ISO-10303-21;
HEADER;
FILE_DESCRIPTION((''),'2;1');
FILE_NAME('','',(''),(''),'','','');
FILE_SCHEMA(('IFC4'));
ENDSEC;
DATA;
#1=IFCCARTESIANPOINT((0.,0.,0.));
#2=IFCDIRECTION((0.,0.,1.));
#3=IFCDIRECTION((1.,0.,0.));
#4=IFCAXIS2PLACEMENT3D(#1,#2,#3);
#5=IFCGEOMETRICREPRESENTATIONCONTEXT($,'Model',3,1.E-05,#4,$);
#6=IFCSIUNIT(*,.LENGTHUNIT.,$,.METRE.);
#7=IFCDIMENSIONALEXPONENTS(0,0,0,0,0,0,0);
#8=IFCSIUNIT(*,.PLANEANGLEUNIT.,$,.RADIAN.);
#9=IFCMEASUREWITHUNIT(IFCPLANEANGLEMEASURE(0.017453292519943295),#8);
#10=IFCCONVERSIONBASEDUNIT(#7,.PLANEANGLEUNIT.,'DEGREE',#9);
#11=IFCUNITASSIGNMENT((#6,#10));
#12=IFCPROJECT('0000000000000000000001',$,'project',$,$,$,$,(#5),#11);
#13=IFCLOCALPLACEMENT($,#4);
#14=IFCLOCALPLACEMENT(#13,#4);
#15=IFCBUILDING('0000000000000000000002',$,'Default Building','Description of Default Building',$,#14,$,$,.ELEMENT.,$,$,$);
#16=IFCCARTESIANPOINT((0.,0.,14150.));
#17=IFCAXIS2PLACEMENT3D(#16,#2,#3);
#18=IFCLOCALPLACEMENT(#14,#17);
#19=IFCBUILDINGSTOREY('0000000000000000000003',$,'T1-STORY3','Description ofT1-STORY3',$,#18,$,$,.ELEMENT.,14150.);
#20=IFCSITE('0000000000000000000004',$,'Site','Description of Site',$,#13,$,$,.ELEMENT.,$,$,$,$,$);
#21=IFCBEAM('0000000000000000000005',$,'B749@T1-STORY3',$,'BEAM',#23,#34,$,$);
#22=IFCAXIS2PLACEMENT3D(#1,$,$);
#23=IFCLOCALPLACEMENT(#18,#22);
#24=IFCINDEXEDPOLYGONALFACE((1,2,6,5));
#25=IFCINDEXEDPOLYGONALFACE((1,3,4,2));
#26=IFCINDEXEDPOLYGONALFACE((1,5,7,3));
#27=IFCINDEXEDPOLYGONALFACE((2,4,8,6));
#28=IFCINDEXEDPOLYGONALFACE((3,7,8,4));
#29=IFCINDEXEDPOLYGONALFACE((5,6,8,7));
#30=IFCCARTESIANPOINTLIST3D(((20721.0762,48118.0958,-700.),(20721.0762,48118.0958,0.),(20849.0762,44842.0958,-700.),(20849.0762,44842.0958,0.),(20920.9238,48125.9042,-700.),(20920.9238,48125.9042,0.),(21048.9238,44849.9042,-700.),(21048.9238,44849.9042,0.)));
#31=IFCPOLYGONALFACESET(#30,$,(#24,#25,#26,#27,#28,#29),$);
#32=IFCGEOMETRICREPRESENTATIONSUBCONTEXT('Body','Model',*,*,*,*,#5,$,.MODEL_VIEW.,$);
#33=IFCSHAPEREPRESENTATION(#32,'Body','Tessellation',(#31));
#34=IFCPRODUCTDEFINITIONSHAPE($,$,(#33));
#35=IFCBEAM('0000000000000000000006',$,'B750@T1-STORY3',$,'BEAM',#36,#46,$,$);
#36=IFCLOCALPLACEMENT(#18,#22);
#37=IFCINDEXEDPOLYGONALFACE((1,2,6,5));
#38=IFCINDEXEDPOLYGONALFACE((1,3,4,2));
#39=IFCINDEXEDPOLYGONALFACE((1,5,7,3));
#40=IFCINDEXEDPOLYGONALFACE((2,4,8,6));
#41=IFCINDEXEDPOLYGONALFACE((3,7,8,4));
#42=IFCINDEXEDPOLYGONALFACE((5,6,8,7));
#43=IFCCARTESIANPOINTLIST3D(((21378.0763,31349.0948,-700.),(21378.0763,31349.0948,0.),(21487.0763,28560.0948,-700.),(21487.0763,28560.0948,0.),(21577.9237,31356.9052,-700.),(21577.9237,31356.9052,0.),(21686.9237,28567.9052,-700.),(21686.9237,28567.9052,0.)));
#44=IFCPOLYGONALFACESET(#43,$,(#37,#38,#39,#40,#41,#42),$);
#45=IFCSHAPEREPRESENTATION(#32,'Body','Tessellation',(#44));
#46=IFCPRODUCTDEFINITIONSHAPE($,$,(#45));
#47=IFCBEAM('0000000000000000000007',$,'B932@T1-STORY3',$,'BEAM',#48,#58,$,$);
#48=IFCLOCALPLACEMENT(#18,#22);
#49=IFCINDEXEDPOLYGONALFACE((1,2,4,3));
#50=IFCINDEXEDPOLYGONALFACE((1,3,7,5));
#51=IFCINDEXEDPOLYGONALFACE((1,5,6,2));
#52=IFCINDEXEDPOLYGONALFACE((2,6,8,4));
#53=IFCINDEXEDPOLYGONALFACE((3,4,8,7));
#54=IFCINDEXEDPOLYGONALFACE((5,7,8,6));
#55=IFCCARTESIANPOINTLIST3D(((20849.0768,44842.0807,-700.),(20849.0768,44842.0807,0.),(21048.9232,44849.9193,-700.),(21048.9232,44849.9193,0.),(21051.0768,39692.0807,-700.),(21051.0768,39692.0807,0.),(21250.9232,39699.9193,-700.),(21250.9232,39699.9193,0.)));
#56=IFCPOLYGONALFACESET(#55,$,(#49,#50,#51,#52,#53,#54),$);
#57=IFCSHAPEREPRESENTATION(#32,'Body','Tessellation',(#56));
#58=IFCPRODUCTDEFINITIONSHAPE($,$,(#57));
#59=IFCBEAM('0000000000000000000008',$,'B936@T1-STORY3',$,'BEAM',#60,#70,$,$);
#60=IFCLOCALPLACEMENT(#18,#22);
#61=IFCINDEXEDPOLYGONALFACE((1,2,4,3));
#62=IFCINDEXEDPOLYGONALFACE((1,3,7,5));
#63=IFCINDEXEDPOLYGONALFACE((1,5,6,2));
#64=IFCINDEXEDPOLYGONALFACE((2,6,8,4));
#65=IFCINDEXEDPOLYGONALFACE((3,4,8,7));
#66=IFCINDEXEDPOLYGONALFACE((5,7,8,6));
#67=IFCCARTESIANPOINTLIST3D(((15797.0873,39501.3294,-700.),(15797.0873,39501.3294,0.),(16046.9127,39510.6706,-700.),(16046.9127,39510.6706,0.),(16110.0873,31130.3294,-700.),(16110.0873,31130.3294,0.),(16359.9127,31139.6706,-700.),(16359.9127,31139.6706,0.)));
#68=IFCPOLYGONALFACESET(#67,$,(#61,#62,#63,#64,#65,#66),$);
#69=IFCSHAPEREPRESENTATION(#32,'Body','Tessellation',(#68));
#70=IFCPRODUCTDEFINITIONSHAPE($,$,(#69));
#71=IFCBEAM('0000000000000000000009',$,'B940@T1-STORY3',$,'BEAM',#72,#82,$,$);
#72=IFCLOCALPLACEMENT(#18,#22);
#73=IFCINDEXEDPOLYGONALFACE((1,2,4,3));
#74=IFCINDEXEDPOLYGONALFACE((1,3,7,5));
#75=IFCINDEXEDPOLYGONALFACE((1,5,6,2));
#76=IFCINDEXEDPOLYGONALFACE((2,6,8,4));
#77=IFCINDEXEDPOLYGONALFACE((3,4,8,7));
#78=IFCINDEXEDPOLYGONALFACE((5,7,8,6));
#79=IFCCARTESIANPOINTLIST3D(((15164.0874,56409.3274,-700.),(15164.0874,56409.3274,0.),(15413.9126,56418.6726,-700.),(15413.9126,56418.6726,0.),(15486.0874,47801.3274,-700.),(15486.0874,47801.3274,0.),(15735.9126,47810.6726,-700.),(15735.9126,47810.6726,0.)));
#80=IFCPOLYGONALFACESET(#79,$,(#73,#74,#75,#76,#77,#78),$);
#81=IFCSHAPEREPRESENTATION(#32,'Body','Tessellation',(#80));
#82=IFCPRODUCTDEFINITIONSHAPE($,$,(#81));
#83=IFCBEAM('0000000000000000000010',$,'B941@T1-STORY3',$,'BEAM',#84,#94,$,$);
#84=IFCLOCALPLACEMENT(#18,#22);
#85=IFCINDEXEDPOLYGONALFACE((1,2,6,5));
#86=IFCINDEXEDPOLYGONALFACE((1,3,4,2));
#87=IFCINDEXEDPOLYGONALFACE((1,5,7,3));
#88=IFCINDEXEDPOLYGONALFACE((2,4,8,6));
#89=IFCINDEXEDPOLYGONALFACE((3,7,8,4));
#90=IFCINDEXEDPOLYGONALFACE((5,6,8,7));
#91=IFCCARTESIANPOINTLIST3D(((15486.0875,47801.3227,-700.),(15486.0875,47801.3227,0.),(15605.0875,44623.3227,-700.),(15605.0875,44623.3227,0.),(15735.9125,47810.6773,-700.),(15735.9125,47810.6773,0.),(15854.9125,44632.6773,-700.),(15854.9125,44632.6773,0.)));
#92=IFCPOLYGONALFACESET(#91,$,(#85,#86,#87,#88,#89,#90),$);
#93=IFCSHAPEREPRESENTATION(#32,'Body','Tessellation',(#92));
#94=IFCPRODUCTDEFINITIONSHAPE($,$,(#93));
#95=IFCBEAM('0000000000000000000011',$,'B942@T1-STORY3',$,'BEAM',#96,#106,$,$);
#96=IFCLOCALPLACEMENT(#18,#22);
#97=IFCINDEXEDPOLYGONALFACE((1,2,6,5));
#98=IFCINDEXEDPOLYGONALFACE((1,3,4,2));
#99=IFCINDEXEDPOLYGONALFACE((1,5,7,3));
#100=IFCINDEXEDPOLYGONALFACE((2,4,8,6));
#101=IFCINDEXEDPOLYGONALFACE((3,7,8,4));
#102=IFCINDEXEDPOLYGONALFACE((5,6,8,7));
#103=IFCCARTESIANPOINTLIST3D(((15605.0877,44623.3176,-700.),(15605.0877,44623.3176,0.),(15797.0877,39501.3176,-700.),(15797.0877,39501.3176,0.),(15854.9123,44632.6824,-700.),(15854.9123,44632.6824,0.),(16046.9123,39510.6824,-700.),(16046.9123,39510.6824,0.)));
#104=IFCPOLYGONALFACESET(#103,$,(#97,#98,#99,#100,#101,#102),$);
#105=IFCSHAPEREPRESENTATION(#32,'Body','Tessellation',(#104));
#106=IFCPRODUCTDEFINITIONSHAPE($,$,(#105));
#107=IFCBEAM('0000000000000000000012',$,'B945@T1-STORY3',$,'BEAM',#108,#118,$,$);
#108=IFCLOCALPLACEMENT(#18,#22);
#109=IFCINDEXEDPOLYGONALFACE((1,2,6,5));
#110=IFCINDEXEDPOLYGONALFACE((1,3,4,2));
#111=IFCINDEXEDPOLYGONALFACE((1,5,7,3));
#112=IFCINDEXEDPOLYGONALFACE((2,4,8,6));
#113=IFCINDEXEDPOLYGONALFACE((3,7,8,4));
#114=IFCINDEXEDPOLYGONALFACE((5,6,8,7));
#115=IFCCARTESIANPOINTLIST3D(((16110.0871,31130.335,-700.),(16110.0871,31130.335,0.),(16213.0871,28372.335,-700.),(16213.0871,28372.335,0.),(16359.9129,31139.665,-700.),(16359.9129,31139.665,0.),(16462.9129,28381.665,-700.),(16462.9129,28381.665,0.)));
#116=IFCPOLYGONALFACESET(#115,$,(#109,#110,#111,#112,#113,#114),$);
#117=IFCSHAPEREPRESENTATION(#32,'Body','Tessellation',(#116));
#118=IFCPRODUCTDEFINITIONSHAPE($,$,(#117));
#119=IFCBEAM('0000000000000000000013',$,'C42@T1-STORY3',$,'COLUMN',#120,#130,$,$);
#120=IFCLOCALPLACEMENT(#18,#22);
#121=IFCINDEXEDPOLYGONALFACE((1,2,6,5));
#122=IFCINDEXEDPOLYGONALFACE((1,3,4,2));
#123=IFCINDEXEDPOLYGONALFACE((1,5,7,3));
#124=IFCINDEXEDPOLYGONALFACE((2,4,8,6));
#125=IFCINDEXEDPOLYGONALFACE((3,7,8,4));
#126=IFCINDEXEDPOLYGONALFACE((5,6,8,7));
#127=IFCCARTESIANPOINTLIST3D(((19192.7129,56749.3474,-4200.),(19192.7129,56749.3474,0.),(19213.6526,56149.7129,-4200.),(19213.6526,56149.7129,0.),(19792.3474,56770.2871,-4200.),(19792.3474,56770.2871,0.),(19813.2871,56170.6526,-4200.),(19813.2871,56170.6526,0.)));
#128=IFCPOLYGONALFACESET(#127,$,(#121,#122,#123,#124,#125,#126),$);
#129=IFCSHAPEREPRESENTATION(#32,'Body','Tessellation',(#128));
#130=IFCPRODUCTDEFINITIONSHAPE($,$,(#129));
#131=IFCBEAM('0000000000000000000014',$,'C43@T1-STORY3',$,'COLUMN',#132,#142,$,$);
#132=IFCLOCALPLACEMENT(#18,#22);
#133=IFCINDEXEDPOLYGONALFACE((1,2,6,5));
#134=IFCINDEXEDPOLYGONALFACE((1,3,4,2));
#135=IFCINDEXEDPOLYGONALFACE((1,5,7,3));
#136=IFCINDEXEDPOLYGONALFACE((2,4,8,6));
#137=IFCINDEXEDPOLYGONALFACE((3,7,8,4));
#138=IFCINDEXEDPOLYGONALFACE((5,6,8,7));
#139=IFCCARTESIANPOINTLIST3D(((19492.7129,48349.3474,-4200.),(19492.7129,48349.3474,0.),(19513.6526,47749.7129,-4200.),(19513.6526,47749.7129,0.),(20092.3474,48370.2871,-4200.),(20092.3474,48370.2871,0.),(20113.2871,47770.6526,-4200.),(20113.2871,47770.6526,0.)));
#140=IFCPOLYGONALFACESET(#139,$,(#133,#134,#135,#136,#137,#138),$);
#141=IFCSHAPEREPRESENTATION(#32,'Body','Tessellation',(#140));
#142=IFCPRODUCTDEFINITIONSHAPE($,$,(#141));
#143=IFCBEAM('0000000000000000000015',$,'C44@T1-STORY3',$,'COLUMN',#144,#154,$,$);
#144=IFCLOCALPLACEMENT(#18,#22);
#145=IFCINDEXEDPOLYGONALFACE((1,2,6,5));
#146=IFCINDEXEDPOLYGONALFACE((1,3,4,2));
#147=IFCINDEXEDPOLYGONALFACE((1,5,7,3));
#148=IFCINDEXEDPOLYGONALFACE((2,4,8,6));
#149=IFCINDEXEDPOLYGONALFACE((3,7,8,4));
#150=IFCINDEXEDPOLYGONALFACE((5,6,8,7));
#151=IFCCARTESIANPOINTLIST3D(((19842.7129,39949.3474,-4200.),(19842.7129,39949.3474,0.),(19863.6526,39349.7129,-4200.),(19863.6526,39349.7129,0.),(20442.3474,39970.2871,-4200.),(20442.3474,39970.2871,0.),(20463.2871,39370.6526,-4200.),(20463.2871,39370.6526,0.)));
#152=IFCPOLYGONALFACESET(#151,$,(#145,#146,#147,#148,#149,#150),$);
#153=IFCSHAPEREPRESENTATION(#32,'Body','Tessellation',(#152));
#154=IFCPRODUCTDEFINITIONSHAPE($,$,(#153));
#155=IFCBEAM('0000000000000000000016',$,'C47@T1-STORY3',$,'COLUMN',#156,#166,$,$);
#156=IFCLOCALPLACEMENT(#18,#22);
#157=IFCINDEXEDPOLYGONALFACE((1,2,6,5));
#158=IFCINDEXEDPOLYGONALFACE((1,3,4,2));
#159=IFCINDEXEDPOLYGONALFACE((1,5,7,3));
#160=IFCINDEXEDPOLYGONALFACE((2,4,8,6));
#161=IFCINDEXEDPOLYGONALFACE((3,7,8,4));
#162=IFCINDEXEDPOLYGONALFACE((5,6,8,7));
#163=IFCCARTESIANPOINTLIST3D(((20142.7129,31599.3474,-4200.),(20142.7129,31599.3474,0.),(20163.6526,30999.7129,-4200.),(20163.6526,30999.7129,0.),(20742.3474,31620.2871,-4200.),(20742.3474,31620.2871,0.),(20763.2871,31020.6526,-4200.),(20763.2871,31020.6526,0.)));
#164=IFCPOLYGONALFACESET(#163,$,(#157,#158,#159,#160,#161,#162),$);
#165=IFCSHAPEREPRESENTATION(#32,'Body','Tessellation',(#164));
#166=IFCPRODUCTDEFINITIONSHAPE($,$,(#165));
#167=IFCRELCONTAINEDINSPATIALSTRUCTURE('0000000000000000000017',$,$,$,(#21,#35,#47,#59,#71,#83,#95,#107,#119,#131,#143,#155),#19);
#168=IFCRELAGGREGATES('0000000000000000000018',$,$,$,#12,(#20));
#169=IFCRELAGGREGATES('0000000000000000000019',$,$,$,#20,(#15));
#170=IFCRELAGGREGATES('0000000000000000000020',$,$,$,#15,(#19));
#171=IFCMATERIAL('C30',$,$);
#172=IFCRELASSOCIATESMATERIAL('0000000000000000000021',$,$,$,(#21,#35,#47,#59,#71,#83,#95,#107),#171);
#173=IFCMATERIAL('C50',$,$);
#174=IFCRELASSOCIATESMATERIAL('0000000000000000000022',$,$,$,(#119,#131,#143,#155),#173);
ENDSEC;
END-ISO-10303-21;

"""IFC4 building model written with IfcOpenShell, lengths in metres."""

from ifc_helpers import new_model, entity, si_unit, converted_unit, frame, origin_with_axes, place, context, subcontext, project, spatial, rectangle, extrude, material, element, save


model = new_model("IFC4")

# Units and contexts
model_context = context("Model", 3, precision=1e-05, world=origin_with_axes())
body_context = subcontext(model_context, "Body", "Model", "MODEL_VIEW")
ifc_project = project(units=[si_unit("LENGTHUNIT", "METRE"), converted_unit("PLANEANGLEUNIT", "DEGREE", entity("IfcPlaneAngleMeasure", 0.017453292519943295), si_unit("PLANEANGLEUNIT", "RADIAN"), dimensions=[0, 0, 0, 0, 0, 0, 0])], contexts=[model_context])

# Site, building, storey
site_placement = place(None, origin_with_axes())
site = spatial("IfcSite", under=ifc_project, at=site_placement, Name="Site", Description="Description of Site", CompositionType="ELEMENT")
building_placement = place(site_placement, origin_with_axes())
building = spatial("IfcBuilding", under=site, at=building_placement, Name="Default Building", Description="Description of Default Building", CompositionType="ELEMENT")
storey_placement = place(building_placement, frame((0.0, 0.0, 14150.0), z_axis=(0.0, 0.0, 1.0), x_axis=(1.0, 0.0, 0.0)))
storey = spatial("IfcBuildingStorey", under=building, at=storey_placement, Name="T1-STORY3", Description="Description ofT1-STORY3", CompositionType="ELEMENT", Elevation=14150.0)

# Beams
ifc_material_1 = material(Name="C30")
beam_1_placement = place(storey_placement, frame((20821.0, 48122.0, -350.0), z_axis=(0.039042, -0.999238, 0.0), x_axis=(0.999238, 0.039042, 0.0)))
element("IfcBeam", 1, at=beam_1_placement, inside=storey, material=ifc_material_1, Name="B749@T1-STORY3", ObjectType="BEAM", context=body_context, shape_type="SweptSolid", body=[
    extrude(rectangle(XDim=200.0, YDim=700.0), origin_with_axes(), (0.0, 0.0, 1.0), 3278.4997),
])
beam_2_placement = place(storey_placement, frame((21478.0, 31353.0, -350.0), z_axis=(0.039052, -0.999237, 0.0), x_axis=(0.999237, 0.039052, 0.0)))
element("IfcBeam", 2, at=beam_2_placement, inside=storey, material=ifc_material_1, Name="B750@T1-STORY3", ObjectType="BEAM", context=body_context, shape_type="SweptSolid", body=[
    extrude(rectangle(XDim=200.0, YDim=700.0), origin_with_axes(), (0.0, 0.0, 1.0), 2791.1292),
])
beam_3_placement = place(storey_placement, frame((20949.0, 44846.0, -350.0), z_axis=(0.039193, -0.999232, 0.0), x_axis=(0.999232, 0.039193, 0.0)))
element("IfcBeam", 3, at=beam_3_placement, inside=storey, material=ifc_material_1, Name="B932@T1-STORY3", ObjectType="BEAM", context=body_context, shape_type="SweptSolid", body=[
    extrude(rectangle(XDim=200.0, YDim=700.0), origin_with_axes(), (0.0, 0.0, 1.0), 5153.96),
])
beam_4_placement = place(storey_placement, frame((15922.0, 39506.0, -350.0), z_axis=(0.037365, -0.999302, 0.0), x_axis=(0.999302, 0.037365, 0.0)))
element("IfcBeam", 4, at=beam_4_placement, inside=storey, material=ifc_material_1, Name="B936@T1-STORY3", ObjectType="BEAM", context=body_context, shape_type="SweptSolid", body=[
    extrude(rectangle(XDim=250.0, YDim=700.0), origin_with_axes(), (0.0, 0.0, 1.0), 8376.8496),
])
beam_5_placement = place(storey_placement, frame((15289.0, 56414.0, -350.0), z_axis=(0.037381, -0.999301, 0.0), x_axis=(0.999301, 0.037381, 0.0)))
element("IfcBeam", 5, at=beam_5_placement, inside=storey, material=ifc_material_1, Name="B940@T1-STORY3", ObjectType="BEAM", context=body_context, shape_type="SweptSolid", body=[
    extrude(rectangle(XDim=250.0, YDim=700.0), origin_with_axes(), (0.0, 0.0, 1.0), 8614.0204),
])
beam_6_placement = place(storey_placement, frame((15611.0, 47806.0, -350.0), z_axis=(0.037419, -0.9993, 0.0), x_axis=(0.9993, 0.037419, 0.0)))
element("IfcBeam", 6, at=beam_6_placement, inside=storey, material=ifc_material_1, Name="B941@T1-STORY3", ObjectType="BEAM", context=body_context, shape_type="SweptSolid", body=[
    extrude(rectangle(XDim=250.0, YDim=700.0), origin_with_axes(), (0.0, 0.0, 1.0), 3180.2272),
])
beam_7_placement = place(storey_placement, frame((15730.0, 44628.0, -350.0), z_axis=(0.037459, -0.999298, 0.0), x_axis=(0.999298, 0.037459, 0.0)))
element("IfcBeam", 7, at=beam_7_placement, inside=storey, material=ifc_material_1, Name="B942@T1-STORY3", ObjectType="BEAM", context=body_context, shape_type="SweptSolid", body=[
    extrude(rectangle(XDim=250.0, YDim=700.0), origin_with_axes(), (0.0, 0.0, 1.0), 5125.5973),
])
beam_8_placement = place(storey_placement, frame((16235.0, 31135.0, -350.0), z_axis=(0.03732, -0.999303, 0.0), x_axis=(0.999303, 0.03732, 0.0)))
element("IfcBeam", 8, at=beam_8_placement, inside=storey, material=ifc_material_1, Name="B945@T1-STORY3", ObjectType="BEAM", context=body_context, shape_type="SweptSolid", body=[
    extrude(rectangle(XDim=250.0, YDim=700.0), origin_with_axes(), (0.0, 0.0, 1.0), 2759.9226),
])
ifc_material_2 = material(Name="C50")
for number, where, z_axis, x_axis, name in (
    (9, (19503.0, 56460.0, -4200.0), (0.0, 0.0, 1.0), (-0.999391, -0.034899, 0.0), "C42@T1-STORY3"),
    (10, (19803.0, 48060.0, -4200.0), (0.0, 0.0, 1.0), (-0.999391, -0.034899, 0.0), "C43@T1-STORY3"),
    (11, (20153.0, 39660.0, -4200.0), (0.0, 0.0, 1.0), (-0.999391, -0.034899, 0.0), "C44@T1-STORY3"),
    (12, (20453.0, 31310.0, -4200.0), (0.0, 0.0, 1.0), (-0.999391, -0.034899, 0.0), "C47@T1-STORY3"),
):
    element("IfcBeam", number, at=place(storey_placement, frame(where, z_axis=z_axis, x_axis=x_axis)), inside=storey, material=ifc_material_2, Name=name, ObjectType="COLUMN", context=body_context, shape_type="SweptSolid", body=[
        extrude(rectangle(XDim=600.0, YDim=600.0), origin_with_axes(), (0.0, 0.0, 1.0), 4200.0),
    ])

save(model, "model.ifc")
